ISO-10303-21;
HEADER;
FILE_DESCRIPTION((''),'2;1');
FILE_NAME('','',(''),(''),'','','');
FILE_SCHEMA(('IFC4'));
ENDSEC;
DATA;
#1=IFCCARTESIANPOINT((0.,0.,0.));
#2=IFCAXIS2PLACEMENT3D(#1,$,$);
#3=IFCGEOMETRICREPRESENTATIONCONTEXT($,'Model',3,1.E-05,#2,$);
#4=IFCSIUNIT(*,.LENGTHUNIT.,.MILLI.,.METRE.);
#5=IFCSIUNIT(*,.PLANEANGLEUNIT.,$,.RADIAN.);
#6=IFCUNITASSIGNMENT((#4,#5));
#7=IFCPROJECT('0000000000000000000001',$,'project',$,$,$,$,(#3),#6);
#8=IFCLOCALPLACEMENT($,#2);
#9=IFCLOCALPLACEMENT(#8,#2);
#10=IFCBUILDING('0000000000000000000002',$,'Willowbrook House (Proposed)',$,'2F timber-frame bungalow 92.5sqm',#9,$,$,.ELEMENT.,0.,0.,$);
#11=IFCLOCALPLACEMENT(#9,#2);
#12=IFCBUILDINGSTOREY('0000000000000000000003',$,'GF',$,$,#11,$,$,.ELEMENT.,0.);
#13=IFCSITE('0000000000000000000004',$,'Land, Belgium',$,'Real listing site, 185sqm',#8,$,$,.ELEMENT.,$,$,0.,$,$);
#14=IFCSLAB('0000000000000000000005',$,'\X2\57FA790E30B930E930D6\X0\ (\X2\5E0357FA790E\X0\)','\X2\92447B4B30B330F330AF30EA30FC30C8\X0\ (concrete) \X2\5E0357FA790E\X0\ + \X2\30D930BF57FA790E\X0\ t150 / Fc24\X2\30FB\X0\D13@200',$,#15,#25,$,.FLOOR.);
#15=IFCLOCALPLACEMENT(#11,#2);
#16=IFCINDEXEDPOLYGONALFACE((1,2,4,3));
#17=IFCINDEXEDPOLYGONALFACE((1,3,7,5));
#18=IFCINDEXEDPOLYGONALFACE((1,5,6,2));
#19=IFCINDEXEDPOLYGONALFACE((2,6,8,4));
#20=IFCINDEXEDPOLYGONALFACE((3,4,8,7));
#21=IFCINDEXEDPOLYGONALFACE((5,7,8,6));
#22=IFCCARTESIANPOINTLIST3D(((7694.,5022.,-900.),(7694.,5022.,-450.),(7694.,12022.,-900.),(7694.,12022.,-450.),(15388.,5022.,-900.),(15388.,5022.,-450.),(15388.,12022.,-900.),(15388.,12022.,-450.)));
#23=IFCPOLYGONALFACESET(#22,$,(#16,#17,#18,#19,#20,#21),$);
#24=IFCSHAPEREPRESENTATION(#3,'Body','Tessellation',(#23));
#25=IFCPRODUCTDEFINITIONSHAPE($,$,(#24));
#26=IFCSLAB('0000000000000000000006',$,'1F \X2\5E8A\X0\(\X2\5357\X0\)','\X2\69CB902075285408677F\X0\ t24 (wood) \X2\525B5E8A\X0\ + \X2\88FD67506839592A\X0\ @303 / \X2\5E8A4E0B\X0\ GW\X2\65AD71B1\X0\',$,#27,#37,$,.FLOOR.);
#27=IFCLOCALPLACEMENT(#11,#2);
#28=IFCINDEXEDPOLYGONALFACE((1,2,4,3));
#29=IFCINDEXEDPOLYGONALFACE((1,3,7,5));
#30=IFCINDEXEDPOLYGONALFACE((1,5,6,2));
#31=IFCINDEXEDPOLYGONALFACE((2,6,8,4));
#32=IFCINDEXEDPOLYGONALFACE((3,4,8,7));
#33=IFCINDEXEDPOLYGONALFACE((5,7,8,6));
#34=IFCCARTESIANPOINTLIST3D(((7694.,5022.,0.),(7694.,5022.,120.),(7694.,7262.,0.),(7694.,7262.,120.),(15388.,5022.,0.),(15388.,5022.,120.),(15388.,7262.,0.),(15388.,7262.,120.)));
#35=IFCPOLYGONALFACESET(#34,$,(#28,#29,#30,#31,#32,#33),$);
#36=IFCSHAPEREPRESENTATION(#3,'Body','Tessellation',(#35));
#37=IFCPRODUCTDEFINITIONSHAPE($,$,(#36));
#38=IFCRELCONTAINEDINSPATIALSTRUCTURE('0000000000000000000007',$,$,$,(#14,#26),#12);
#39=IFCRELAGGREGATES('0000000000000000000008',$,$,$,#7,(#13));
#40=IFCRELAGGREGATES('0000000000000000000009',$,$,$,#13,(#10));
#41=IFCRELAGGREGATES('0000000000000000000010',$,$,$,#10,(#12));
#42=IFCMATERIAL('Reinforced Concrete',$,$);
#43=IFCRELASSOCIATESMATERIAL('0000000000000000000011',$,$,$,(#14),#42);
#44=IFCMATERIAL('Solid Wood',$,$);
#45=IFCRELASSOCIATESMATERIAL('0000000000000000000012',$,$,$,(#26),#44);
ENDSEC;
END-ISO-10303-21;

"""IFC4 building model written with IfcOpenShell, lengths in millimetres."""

from ifc_helpers import new_model, si_unit, frame, frame_2d, origin, place, context, project, spatial, rectangle, extrude, material, element, save


model = new_model("IFC4")

# Units and contexts
model_context = context("Model", 3, precision=1e-05, world=origin())
ifc_project = project(units=[si_unit("LENGTHUNIT", "METRE", prefix="MILLI"), si_unit("PLANEANGLEUNIT", "RADIAN")], contexts=[model_context])

# Site, building, storey
site_placement = place(None, origin())
site = spatial("IfcSite", under=ifc_project, at=site_placement, Name="Land, Belgium", ObjectType="Real listing site, 185sqm", CompositionType="ELEMENT", RefElevation=0.0)
building_placement = place(site_placement, origin())
building = spatial("IfcBuilding", under=site, at=building_placement, Name="Willowbrook House (Proposed)", ObjectType="2F timber-frame bungalow 92.5sqm", CompositionType="ELEMENT", ElevationOfRefHeight=0.0, ElevationOfTerrain=0.0)
storey_placement = place(building_placement, origin())
storey = spatial("IfcBuildingStorey", under=building, at=storey_placement, Name="GF", CompositionType="ELEMENT", Elevation=0.0)

# Slabs
ifc_material_1 = material(Name="Reinforced Concrete")
slab_1_placement = place(storey_placement, frame((3847.0, 2511.0, -450.0)))
element("IfcSlab", 1, at=slab_1_placement, inside=storey, material=ifc_material_1, Name="基礎スラブ (布基礎)", Description="鉄筋コンクリート (concrete) 布基礎 + ベタ基礎 t150 / Fc24・D13@200", PredefinedType="FLOOR", context=model_context, shape_type="SweptSolid", body=[
    extrude(rectangle(XDim=7694.0, YDim=7000.0, at=frame_2d((3847.0, 3500.0))), frame((3847.0, 2511.0, -450.0)), (0.0, 0.0, 1.0), 450.0),
])
ifc_material_2 = material(Name="Solid Wood")
slab_2_placement = place(storey_placement, frame((3847.0, 2511.0, 0.0)))
element("IfcSlab", 2, at=slab_2_placement, inside=storey, material=ifc_material_2, Name="1F 床(南)", Description="構造用合板 t24 (wood) 剛床 + 製材根太 @303 / 床下 GW断熱", PredefinedType="FLOOR", context=model_context, shape_type="SweptSolid", body=[
    extrude(rectangle(XDim=7694.0, YDim=2240.0, at=frame_2d((3847.0, 1120.0))), frame((3847.0, 2511.0, 0.0)), (0.0, 0.0, 1.0), 120.0),
])

save(model, "model.ifc")
